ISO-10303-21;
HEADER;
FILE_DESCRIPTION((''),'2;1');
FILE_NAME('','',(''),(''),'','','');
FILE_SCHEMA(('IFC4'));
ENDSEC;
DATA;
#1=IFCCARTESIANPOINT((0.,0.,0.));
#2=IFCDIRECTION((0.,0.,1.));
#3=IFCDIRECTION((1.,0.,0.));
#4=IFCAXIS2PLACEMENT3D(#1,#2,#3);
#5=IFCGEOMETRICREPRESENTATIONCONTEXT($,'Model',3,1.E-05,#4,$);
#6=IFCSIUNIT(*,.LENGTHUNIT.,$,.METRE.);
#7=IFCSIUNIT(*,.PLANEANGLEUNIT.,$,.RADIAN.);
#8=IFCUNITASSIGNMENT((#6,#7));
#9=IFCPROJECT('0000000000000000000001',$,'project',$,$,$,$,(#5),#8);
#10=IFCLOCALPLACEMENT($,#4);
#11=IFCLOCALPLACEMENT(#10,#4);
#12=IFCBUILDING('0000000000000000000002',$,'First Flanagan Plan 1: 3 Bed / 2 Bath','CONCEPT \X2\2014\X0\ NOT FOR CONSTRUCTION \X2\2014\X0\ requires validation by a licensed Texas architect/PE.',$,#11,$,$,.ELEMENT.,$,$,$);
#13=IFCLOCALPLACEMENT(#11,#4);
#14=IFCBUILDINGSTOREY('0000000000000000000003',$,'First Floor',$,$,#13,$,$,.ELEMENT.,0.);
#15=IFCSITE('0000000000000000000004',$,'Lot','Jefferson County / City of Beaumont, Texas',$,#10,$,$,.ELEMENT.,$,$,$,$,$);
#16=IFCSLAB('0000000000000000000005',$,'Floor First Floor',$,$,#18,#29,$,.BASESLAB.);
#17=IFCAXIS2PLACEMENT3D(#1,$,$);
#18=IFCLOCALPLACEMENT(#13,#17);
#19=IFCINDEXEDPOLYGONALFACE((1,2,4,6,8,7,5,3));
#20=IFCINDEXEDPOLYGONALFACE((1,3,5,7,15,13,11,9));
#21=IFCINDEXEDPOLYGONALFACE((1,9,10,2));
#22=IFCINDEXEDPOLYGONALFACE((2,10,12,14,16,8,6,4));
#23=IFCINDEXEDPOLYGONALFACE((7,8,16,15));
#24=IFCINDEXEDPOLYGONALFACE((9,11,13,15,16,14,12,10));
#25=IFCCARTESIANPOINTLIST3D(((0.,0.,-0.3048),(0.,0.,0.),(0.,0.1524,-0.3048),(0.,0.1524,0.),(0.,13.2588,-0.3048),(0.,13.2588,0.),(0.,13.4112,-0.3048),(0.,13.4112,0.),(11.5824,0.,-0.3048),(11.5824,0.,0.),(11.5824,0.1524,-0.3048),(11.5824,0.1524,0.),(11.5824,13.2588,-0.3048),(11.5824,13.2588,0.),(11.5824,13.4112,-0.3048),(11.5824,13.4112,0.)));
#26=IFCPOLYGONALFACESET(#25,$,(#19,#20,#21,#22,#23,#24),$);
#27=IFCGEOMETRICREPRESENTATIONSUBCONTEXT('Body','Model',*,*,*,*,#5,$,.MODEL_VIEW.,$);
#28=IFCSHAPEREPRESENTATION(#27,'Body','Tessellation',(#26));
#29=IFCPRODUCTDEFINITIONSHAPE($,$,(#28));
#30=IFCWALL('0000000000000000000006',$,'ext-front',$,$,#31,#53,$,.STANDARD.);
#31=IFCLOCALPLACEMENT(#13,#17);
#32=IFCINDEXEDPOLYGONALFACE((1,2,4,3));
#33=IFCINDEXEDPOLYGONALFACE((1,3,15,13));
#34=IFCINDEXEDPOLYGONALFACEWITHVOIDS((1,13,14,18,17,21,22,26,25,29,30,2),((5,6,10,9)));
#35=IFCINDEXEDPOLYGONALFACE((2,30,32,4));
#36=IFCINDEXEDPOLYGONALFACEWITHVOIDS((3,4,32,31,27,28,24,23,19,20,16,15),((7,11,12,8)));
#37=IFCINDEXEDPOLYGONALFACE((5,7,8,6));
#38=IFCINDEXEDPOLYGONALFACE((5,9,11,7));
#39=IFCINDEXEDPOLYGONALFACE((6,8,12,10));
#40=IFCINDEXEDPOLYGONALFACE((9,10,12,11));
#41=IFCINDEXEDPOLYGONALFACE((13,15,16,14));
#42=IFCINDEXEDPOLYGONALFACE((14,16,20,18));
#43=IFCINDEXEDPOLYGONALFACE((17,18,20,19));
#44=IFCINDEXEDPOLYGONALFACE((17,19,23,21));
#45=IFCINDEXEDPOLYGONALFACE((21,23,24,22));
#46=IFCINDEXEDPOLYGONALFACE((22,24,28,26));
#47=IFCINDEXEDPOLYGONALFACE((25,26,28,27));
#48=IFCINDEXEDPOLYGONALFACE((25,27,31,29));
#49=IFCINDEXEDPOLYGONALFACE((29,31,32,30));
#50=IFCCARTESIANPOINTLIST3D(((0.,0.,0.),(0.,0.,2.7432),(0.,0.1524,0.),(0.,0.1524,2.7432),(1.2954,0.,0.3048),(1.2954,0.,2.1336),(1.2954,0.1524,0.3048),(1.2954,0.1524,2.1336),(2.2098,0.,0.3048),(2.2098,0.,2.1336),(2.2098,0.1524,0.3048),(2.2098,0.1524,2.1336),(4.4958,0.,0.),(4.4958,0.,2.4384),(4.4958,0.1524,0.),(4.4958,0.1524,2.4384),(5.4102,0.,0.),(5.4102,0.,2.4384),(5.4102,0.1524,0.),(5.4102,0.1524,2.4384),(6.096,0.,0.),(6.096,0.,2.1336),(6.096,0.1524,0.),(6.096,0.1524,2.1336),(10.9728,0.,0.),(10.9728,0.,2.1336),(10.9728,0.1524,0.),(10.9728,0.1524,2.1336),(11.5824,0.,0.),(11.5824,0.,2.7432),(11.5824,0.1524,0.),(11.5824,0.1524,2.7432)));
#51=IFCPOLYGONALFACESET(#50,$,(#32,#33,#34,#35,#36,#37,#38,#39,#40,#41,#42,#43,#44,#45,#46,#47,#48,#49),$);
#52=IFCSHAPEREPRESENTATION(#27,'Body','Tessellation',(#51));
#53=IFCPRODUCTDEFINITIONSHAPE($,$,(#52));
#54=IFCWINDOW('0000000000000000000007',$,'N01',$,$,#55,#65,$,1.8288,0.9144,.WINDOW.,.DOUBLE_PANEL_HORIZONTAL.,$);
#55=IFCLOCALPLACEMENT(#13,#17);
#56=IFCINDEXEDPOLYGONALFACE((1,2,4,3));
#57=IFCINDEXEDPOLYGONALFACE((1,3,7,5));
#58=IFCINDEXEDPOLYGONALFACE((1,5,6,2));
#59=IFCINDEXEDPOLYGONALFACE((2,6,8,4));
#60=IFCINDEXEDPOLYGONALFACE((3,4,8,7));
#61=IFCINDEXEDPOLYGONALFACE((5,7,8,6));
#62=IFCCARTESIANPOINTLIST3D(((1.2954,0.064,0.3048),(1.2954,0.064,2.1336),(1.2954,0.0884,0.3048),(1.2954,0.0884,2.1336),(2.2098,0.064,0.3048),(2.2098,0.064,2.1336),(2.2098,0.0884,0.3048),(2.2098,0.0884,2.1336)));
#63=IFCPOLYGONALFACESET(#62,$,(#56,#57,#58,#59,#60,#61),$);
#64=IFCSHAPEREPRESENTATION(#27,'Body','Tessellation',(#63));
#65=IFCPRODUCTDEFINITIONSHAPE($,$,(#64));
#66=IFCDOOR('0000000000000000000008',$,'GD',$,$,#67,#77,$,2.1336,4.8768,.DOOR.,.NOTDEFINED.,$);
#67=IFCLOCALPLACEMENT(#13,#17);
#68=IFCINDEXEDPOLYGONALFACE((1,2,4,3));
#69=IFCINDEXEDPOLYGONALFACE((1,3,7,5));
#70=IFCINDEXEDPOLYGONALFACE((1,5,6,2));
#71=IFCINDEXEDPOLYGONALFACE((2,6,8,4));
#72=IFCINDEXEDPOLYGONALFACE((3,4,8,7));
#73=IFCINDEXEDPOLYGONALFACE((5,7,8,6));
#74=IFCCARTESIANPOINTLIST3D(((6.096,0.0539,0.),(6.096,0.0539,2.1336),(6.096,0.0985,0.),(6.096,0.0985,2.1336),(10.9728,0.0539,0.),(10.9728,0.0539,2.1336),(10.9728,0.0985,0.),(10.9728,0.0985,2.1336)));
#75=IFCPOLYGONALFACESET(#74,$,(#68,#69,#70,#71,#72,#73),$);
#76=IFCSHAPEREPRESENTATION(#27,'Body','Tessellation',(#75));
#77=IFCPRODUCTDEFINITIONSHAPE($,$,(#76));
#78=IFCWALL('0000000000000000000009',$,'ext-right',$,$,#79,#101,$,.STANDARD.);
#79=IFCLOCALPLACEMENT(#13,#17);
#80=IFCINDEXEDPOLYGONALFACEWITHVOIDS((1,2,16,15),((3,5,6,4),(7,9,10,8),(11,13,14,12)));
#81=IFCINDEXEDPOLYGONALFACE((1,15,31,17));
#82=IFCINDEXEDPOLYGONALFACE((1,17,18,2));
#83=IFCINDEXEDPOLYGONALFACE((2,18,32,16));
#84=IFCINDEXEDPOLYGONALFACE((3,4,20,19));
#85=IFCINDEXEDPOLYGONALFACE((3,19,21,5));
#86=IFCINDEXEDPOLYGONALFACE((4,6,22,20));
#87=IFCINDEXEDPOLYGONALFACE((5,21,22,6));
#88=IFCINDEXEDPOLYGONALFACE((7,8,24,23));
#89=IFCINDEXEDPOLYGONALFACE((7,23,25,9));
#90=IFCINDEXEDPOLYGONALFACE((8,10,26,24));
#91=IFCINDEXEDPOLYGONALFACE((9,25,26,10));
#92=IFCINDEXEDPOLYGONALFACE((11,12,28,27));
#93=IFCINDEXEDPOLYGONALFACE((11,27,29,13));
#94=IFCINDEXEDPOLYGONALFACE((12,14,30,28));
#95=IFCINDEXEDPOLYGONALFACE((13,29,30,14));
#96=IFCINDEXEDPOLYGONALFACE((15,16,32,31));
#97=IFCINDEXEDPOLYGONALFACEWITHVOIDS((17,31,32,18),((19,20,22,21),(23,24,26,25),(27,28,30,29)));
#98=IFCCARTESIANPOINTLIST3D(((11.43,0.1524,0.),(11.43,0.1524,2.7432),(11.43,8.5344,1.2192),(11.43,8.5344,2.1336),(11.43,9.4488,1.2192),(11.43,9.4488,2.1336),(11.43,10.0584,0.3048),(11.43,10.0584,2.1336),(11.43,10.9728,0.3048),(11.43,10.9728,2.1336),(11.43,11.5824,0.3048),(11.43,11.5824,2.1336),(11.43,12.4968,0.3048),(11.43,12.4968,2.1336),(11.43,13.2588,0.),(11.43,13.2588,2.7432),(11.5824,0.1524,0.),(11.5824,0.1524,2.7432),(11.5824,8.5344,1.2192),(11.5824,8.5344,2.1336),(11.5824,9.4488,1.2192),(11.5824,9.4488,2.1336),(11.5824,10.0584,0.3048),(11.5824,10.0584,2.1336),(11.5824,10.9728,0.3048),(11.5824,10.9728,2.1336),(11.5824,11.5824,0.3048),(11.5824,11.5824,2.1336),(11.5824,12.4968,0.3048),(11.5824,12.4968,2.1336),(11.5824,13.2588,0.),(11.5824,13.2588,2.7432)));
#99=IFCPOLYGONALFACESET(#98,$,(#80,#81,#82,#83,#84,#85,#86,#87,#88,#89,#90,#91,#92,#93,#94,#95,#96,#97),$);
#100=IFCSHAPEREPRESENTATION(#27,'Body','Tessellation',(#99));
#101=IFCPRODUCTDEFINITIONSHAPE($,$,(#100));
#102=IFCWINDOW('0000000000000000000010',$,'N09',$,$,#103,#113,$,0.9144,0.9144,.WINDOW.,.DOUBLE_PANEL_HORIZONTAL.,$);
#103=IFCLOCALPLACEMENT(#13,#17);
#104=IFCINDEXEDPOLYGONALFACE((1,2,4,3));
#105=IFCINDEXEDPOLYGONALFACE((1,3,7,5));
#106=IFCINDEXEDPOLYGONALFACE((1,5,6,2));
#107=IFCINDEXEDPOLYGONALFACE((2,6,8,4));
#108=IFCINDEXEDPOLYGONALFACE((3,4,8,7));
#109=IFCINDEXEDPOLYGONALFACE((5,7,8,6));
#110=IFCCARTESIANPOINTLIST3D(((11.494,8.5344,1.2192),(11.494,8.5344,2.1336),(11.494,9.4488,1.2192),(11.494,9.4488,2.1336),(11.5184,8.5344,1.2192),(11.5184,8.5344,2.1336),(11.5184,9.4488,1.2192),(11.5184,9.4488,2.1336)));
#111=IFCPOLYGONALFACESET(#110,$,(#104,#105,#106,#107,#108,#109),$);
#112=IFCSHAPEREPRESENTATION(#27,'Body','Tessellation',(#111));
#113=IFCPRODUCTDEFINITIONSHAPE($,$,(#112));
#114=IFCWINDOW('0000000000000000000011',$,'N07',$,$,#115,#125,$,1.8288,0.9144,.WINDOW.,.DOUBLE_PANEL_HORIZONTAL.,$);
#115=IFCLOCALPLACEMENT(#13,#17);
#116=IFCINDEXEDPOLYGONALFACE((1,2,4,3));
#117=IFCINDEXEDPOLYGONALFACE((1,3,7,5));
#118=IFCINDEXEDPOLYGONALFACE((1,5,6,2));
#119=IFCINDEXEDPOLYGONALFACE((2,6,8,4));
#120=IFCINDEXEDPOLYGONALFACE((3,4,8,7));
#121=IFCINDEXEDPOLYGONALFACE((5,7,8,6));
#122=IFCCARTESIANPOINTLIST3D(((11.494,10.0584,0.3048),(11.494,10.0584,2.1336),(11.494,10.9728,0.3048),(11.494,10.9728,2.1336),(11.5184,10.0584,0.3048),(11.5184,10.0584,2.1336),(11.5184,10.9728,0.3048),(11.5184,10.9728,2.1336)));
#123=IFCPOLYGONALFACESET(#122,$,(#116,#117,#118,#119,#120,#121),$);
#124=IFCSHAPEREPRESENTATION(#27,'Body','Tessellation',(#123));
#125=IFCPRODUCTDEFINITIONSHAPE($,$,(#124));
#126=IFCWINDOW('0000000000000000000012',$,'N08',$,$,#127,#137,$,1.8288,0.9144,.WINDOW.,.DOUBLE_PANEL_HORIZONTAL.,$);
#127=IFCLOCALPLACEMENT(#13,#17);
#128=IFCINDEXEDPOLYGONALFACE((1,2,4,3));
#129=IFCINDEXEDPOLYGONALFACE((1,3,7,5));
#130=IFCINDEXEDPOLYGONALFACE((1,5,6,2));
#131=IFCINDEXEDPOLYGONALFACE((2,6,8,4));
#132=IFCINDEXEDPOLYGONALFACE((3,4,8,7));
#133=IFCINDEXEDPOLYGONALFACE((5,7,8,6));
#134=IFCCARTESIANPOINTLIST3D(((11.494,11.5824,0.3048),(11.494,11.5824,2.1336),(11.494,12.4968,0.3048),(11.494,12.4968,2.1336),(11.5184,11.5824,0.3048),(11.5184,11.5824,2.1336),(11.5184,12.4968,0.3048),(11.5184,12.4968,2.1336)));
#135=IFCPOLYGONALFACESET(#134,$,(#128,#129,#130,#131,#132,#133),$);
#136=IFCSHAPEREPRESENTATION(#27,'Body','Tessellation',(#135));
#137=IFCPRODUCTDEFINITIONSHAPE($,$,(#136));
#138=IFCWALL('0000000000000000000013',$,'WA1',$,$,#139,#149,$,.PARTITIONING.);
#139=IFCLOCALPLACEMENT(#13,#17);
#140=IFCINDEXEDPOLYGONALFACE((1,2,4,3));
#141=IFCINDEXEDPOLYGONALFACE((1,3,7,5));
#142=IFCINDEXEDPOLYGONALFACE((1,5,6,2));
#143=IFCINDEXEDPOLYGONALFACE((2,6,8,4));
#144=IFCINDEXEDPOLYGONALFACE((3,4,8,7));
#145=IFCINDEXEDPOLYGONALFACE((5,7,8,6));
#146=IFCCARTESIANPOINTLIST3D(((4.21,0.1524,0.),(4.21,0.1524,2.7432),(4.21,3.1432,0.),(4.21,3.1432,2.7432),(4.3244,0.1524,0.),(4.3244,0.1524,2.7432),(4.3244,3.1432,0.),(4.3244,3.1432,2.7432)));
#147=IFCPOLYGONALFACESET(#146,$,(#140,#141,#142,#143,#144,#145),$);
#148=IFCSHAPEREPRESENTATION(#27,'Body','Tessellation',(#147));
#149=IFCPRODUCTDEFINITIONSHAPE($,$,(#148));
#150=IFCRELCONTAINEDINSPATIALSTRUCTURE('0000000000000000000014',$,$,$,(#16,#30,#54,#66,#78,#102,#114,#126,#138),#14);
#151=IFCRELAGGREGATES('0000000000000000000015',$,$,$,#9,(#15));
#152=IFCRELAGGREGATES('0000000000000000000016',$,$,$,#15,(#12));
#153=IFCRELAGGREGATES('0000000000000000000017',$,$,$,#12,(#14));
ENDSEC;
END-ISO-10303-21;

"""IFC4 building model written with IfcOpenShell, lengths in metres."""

from ifc_helpers import new_model, si_unit, frame, frame_2d, origin_with_axes, place, context, subcontext, project, spatial, polyline, rectangle, outline, extrude, element, fill, save


model = new_model("IFC4")

# Units and contexts
model_context = context("Model", 3, precision=1e-05, world=origin_with_axes())
body_context = subcontext(model_context, "Body", "Model", "MODEL_VIEW")
ifc_project = project(units=[si_unit("LENGTHUNIT", "METRE"), si_unit("PLANEANGLEUNIT", "RADIAN")], contexts=[model_context])

# Site, building, storey
site_placement = place(None, origin_with_axes())
site = spatial("IfcSite", under=ifc_project, at=site_placement, Name="Lot", Description="Jefferson County / City of Beaumont, Texas", CompositionType="ELEMENT")
building_placement = place(site_placement, origin_with_axes())
building = spatial("IfcBuilding", under=site, at=building_placement, Name="First Flanagan Plan 1: 3 Bed / 2 Bath", Description="CONCEPT — NOT FOR CONSTRUCTION — requires validation by a licensed Texas architect/PE.", CompositionType="ELEMENT")
storey_placement = place(building_placement, origin_with_axes())
storey = spatial("IfcBuildingStorey", under=building, at=storey_placement, Name="First Floor", CompositionType="ELEMENT", Elevation=0.0)

# Slab
slab_placement = place(storey_placement, frame((0.0, 0.0, -0.3048), z_axis=(0.0, 0.0, 1.0), x_axis=(1.0, 0.0, 0.0)))
element("IfcSlab", 1, at=slab_placement, inside=storey, Name="Floor First Floor", PredefinedType="BASESLAB", context=body_context, shape_type="SweptSolid", body=[
    extrude(outline(polyline([(11.5824, 0.1524), (11.5824, 0.0), (0.0, 0.0), (0.0, 0.1524), (0.0, 13.2588), (0.0, 13.4112), (11.5824, 13.4112), (11.5824, 13.2588), (11.5824, 0.1524)])), origin_with_axes(), (0.0, 0.0, 1.0), 0.3048),
])

# Wall, openings, window, door
wall_1_placement = place(storey_placement, frame((0.0, 0.0762, 0.0), z_axis=(0.0, 0.0, 1.0), x_axis=(1.0, 0.0, 0.0)))
wall_1 = element("IfcWall", 2, at=wall_1_placement, inside=storey, Name="ext-front", PredefinedType="STANDARD", context=body_context, shape_type="SweptSolid", body=[
    extrude(rectangle(XDim=11.5824, YDim=0.1524, at=frame_2d((5.7912, 0.0), x_axis=(1.0, 0.0))), origin_with_axes(), (0.0, 0.0, 1.0), 2.7432),
])
opening_1_placement = place(wall_1_placement, frame((1.2954, 0.0, 0.3048), z_axis=(0.0, 0.0, 1.0), x_axis=(1.0, 0.0, 0.0)))
opening_1 = element("IfcOpeningElement", 3, at=opening_1_placement, cuts=wall_1, PredefinedType="OPENING", context=body_context, shape_type="SweptSolid", body=[
    extrude(rectangle(XDim=0.9144, YDim=0.1829, at=frame_2d((0.4572, 0.0), x_axis=(1.0, 0.0))), origin_with_axes(), (0.0, 0.0, 1.0), 1.8288),
])
opening_2_placement = place(wall_1_placement, frame((4.4958, 0.0, 0.0), z_axis=(0.0, 0.0, 1.0), x_axis=(1.0, 0.0, 0.0)))
element("IfcOpeningElement", 4, at=opening_2_placement, cuts=wall_1, PredefinedType="OPENING", context=body_context, shape_type="SweptSolid", body=[
    extrude(rectangle(XDim=0.9144, YDim=0.1829, at=frame_2d((0.4572, 0.0), x_axis=(1.0, 0.0))), origin_with_axes(), (0.0, 0.0, 1.0), 2.4384),
])
opening_3_placement = place(wall_1_placement, frame((6.096, 0.0, 0.0), z_axis=(0.0, 0.0, 1.0), x_axis=(1.0, 0.0, 0.0)))
opening_3 = element("IfcOpeningElement", 5, at=opening_3_placement, cuts=wall_1, PredefinedType="OPENING", context=body_context, shape_type="SweptSolid", body=[
    extrude(rectangle(XDim=4.8768, YDim=0.1829, at=frame_2d((2.4384, 0.0), x_axis=(1.0, 0.0))), origin_with_axes(), (0.0, 0.0, 1.0), 2.1336),
])
window_1_placement = place(opening_1_placement, origin_with_axes())
window_1 = element("IfcWindow", 6, at=window_1_placement, inside=storey, Name="N01", OverallHeight=1.8288, OverallWidth=0.9144, PartitioningType="DOUBLE_PANEL_HORIZONTAL", PredefinedType="WINDOW", context=body_context, shape_type="SweptSolid", body=[
    extrude(rectangle(XDim=0.9144, YDim=0.0244, at=frame_2d((0.4572, 0.0), x_axis=(1.0, 0.0))), origin_with_axes(), (0.0, 0.0, 1.0), 1.8288),
])
fill(opening_1, window_1)
door_1_placement = place(opening_3_placement, origin_with_axes())
door_1 = element("IfcDoor", 7, at=door_1_placement, inside=storey, Name="GD", OperationType="NOTDEFINED", OverallHeight=2.1336, OverallWidth=4.8768, PredefinedType="DOOR", context=body_context, shape_type="SweptSolid", body=[
    extrude(rectangle(XDim=4.8768, YDim=0.0445, at=frame_2d((2.4384, 0.0), x_axis=(1.0, 0.0))), origin_with_axes(), (0.0, 0.0, 1.0), 2.1336),
])
fill(opening_3, door_1)

# Wall, openings, windows
wall_2_placement = place(storey_placement, frame((11.5062, 0.1524, 0.0), z_axis=(0.0, 0.0, 1.0), x_axis=(0.0, 1.0, 0.0)))
wall_2 = element("IfcWall", 8, at=wall_2_placement, inside=storey, Name="ext-right", PredefinedType="STANDARD", context=body_context, shape_type="SweptSolid", body=[
    extrude(rectangle(XDim=13.1064, YDim=0.1524, at=frame_2d((6.5532, 0.0), x_axis=(1.0, 0.0))), origin_with_axes(), (0.0, 0.0, 1.0), 2.7432),
])
opening_4_placement = place(wall_2_placement, frame((8.382, 0.0, 1.2192), z_axis=(0.0, 0.0, 1.0), x_axis=(1.0, 0.0, 0.0)))
opening_4 = element("IfcOpeningElement", 9, at=opening_4_placement, cuts=wall_2, PredefinedType="OPENING", context=body_context, shape_type="SweptSolid", body=[
    extrude(rectangle(XDim=0.9144, YDim=0.1829, at=frame_2d((0.4572, 0.0), x_axis=(1.0, 0.0))), origin_with_axes(), (0.0, 0.0, 1.0), 0.9144),
])
opening_5_placement = place(wall_2_placement, frame((9.906, 0.0, 0.3048), z_axis=(0.0, 0.0, 1.0), x_axis=(1.0, 0.0, 0.0)))
opening_5 = element("IfcOpeningElement", 10, at=opening_5_placement, cuts=wall_2, PredefinedType="OPENING", context=body_context, shape_type="SweptSolid", body=[
    extrude(rectangle(XDim=0.9144, YDim=0.1829, at=frame_2d((0.4572, 0.0), x_axis=(1.0, 0.0))), origin_with_axes(), (0.0, 0.0, 1.0), 1.8288),
])
opening_6_placement = place(wall_2_placement, frame((11.43, 0.0, 0.3048), z_axis=(0.0, 0.0, 1.0), x_axis=(1.0, 0.0, 0.0)))
opening_6 = element("IfcOpeningElement", 11, at=opening_6_placement, cuts=wall_2, PredefinedType="OPENING", context=body_context, shape_type="SweptSolid", body=[
    extrude(rectangle(XDim=0.9144, YDim=0.1829, at=frame_2d((0.4572, 0.0), x_axis=(1.0, 0.0))), origin_with_axes(), (0.0, 0.0, 1.0), 1.8288),
])
window_2_placement = place(opening_4_placement, origin_with_axes())
window_2 = element("IfcWindow", 12, at=window_2_placement, inside=storey, Name="N09", OverallHeight=0.9144, OverallWidth=0.9144, PartitioningType="DOUBLE_PANEL_HORIZONTAL", PredefinedType="WINDOW", context=body_context, shape_type="SweptSolid", body=[
    extrude(rectangle(XDim=0.9144, YDim=0.0244, at=frame_2d((0.4572, 0.0), x_axis=(1.0, 0.0))), origin_with_axes(), (0.0, 0.0, 1.0), 0.9144),
])
fill(opening_4, window_2)
window_3_placement = place(opening_5_placement, origin_with_axes())
window_3 = element("IfcWindow", 13, at=window_3_placement, inside=storey, Name="N07", OverallHeight=1.8288, OverallWidth=0.9144, PartitioningType="DOUBLE_PANEL_HORIZONTAL", PredefinedType="WINDOW", context=body_context, shape_type="SweptSolid", body=[
    extrude(rectangle(XDim=0.9144, YDim=0.0244, at=frame_2d((0.4572, 0.0), x_axis=(1.0, 0.0))), origin_with_axes(), (0.0, 0.0, 1.0), 1.8288),
])
fill(opening_5, window_3)
window_4_placement = place(opening_6_placement, origin_with_axes())
window_4 = element("IfcWindow", 14, at=window_4_placement, inside=storey, Name="N08", OverallHeight=1.8288, OverallWidth=0.9144, PartitioningType="DOUBLE_PANEL_HORIZONTAL", PredefinedType="WINDOW", context=body_context, shape_type="SweptSolid", body=[
    extrude(rectangle(XDim=0.9144, YDim=0.0244, at=frame_2d((0.4572, 0.0), x_axis=(1.0, 0.0))), origin_with_axes(), (0.0, 0.0, 1.0), 1.8288),
])
fill(opening_6, window_4)

# Wall
wall_3_placement = place(storey_placement, frame((4.2672, 0.1524, 0.0), z_axis=(0.0, 0.0, 1.0), x_axis=(0.0, 1.0, 0.0)))
element("IfcWall", 15, at=wall_3_placement, inside=storey, Name="WA1", PredefinedType="PARTITIONING", context=body_context, shape_type="SweptSolid", body=[
    extrude(rectangle(XDim=2.9909, YDim=0.1143, at=frame_2d((1.4954, 0.0), x_axis=(1.0, 0.0))), origin_with_axes(), (0.0, 0.0, 1.0), 2.7432),
])

save(model, "model.ifc")
